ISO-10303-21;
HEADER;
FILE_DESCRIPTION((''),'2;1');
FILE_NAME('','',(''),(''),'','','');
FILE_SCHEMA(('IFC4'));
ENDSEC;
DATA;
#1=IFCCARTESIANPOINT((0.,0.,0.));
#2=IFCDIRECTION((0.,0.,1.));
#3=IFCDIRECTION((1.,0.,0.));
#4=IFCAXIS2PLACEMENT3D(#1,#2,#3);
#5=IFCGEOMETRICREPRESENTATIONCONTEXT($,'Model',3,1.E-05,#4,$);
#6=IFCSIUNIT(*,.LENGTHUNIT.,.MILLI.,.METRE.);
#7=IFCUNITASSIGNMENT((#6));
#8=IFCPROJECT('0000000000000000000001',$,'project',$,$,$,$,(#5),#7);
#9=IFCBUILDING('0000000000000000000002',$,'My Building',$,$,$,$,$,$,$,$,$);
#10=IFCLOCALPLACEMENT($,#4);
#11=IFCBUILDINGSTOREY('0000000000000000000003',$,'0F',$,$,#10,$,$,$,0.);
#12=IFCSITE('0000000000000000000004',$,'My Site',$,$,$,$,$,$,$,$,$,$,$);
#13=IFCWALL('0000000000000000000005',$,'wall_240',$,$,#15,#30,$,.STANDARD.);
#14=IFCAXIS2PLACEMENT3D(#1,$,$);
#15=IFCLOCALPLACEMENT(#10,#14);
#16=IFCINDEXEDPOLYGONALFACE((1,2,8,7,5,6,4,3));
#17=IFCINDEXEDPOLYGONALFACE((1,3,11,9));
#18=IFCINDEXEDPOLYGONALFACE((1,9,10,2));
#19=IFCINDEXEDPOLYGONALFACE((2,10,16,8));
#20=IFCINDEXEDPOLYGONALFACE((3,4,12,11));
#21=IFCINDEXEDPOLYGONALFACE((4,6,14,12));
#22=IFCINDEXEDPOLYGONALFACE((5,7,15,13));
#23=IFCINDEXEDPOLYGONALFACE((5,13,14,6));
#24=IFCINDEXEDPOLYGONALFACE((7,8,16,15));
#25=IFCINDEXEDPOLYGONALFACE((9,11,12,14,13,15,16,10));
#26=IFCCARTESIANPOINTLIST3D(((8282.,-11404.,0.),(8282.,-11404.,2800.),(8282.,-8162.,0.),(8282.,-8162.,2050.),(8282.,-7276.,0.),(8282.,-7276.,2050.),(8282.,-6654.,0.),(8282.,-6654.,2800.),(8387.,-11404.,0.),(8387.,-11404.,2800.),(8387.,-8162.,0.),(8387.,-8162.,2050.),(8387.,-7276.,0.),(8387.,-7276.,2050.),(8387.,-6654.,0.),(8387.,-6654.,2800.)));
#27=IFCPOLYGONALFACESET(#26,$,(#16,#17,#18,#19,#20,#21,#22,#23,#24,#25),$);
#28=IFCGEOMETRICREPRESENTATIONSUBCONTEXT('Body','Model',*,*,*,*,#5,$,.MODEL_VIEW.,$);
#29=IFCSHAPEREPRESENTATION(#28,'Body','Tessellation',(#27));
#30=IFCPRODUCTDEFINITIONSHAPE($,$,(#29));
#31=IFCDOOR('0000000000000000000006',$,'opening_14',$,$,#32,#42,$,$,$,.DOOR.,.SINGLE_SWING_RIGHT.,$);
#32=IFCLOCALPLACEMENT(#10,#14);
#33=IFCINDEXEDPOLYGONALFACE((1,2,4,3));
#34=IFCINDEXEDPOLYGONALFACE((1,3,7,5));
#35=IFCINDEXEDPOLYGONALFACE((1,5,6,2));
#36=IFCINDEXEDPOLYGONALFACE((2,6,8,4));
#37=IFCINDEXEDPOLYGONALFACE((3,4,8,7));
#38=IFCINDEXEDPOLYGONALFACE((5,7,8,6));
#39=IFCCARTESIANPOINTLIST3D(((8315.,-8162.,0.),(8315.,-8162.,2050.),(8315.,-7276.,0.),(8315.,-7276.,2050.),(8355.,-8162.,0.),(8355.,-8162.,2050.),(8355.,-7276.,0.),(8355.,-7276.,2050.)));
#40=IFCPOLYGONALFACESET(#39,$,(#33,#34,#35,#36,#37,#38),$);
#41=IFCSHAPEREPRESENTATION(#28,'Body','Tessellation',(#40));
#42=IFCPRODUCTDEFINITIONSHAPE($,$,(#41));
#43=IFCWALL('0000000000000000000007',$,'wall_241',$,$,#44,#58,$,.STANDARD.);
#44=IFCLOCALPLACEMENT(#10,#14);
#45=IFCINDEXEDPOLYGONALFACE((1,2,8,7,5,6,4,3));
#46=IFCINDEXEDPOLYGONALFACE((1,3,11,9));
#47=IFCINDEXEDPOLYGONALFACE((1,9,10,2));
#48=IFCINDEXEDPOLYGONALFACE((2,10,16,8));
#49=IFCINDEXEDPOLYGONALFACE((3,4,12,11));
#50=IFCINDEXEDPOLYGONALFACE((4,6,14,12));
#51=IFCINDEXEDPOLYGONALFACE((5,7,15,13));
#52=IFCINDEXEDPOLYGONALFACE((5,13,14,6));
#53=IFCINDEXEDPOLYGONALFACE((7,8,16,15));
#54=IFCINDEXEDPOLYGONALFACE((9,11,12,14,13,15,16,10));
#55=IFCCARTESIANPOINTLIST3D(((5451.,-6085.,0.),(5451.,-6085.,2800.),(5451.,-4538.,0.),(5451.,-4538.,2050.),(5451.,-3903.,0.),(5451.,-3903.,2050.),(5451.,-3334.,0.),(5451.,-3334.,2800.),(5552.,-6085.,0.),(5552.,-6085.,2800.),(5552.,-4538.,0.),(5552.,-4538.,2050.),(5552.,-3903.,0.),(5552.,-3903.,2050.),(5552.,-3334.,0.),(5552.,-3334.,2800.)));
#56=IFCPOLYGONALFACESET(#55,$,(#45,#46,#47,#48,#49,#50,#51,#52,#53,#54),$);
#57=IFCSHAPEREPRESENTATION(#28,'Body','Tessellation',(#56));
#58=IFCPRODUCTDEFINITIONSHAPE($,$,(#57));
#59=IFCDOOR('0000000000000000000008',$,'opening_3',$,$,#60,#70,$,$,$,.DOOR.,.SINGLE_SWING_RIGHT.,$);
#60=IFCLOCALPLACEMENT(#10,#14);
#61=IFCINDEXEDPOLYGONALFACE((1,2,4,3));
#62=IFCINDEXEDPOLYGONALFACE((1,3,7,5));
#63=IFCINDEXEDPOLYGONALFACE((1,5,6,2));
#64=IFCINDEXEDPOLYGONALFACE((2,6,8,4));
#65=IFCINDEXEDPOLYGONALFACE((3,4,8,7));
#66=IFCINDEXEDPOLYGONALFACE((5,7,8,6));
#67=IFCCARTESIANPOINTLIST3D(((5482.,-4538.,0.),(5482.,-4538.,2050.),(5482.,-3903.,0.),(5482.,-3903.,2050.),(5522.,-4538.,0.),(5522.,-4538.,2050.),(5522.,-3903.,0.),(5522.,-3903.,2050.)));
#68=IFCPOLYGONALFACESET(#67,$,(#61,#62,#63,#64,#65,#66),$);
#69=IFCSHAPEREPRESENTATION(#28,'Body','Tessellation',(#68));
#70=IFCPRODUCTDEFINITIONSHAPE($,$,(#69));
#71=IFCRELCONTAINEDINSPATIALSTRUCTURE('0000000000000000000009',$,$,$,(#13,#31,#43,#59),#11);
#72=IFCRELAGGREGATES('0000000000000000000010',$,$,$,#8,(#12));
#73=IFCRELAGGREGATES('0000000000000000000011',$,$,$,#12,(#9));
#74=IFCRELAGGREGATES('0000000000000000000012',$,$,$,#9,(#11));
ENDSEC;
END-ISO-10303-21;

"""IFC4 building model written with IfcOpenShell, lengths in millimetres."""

from ifc_helpers import new_model, si_unit, origin_with_axes, place, context, subcontext, project, spatial, indexed_curve, outline, extrude, element, fill, save


model = new_model("IFC4")

# Units and contexts
model_context = context("Model", 3, precision=1e-05, world=origin_with_axes())
body_context = subcontext(model_context, "Body", "Model", "MODEL_VIEW")
ifc_project = project(units=[si_unit("LENGTHUNIT", "METRE", prefix="MILLI")], contexts=[model_context])

# Site, building, storey
site = spatial("IfcSite", under=ifc_project, Name="My Site")
building = spatial("IfcBuilding", under=site, Name="My Building")
storey_placement = place(None, origin_with_axes())
storey = spatial("IfcBuildingStorey", under=building, at=storey_placement, Name="0F", Elevation=0.0)

# Walls, openings, doors
wall_1_placement = place(storey_placement, origin_with_axes())
wall_1 = element("IfcWall", 1, at=wall_1_placement, inside=storey, Name="wall_240", PredefinedType="STANDARD", context=body_context, shape_type="SweptSolid", body=[
    extrude(outline(indexed_curve([(8282.0, -6654.0), (8282.0, -11404.0), (8387.0, -11404.0), (8387.0, -6654.0), (8282.0, -6654.0)])), None, (0.0, 0.0, 1.0), 2800.0),
])
opening_1_placement = place(wall_1_placement, origin_with_axes())
opening_1 = element("IfcOpeningElement", 2, at=opening_1_placement, cuts=wall_1, ObjectType="Opening", context=body_context, shape_type="SweptSolid", body=[
    extrude(outline(indexed_curve([(8216.0, -8162.0), (8453.0, -8162.0), (8453.0, -7276.0), (8216.0, -7276.0), (8216.0, -8162.0)])), None, (0.0, 0.0, 1.0), 2050.0),
])
door_1_placement = place(opening_1_placement, origin_with_axes())
door_1 = element("IfcDoor", 3, at=door_1_placement, inside=storey, Name="opening_14", OperationType="SINGLE_SWING_RIGHT", PredefinedType="DOOR", context=body_context, shape_type="SweptSolid", body=[
    extrude(outline(indexed_curve([(8315.0, -8162.0), (8355.0, -8162.0), (8355.0, -7276.0), (8315.0, -7276.0), (8315.0, -8162.0)])), None, (0.0, 0.0, 1.0), 2050.0),
])
fill(opening_1, door_1)
wall_2_placement = place(storey_placement, origin_with_axes())
wall_2 = element("IfcWall", 4, at=wall_2_placement, inside=storey, Name="wall_241", PredefinedType="STANDARD", context=body_context, shape_type="SweptSolid", body=[
    extrude(outline(indexed_curve([(5451.0, -3334.0), (5451.0, -6085.0), (5552.0, -6085.0), (5552.0, -3334.0), (5451.0, -3334.0)])), None, (0.0, 0.0, 1.0), 2800.0),
])
opening_2_placement = place(wall_2_placement, origin_with_axes())
opening_2 = element("IfcOpeningElement", 5, at=opening_2_placement, cuts=wall_2, ObjectType="Opening", context=body_context, shape_type="SweptSolid", body=[
    extrude(outline(indexed_curve([(5385.0, -4538.0), (5618.0, -4538.0), (5618.0, -3903.0), (5385.0, -3903.0), (5385.0, -4538.0)])), None, (0.0, 0.0, 1.0), 2050.0),
])
door_2_placement = place(opening_2_placement, origin_with_axes())
door_2 = element("IfcDoor", 6, at=door_2_placement, inside=storey, Name="opening_3", OperationType="SINGLE_SWING_RIGHT", PredefinedType="DOOR", context=body_context, shape_type="SweptSolid", body=[
    extrude(outline(indexed_curve([(5482.0, -4538.0), (5522.0, -4538.0), (5522.0, -3903.0), (5482.0, -3903.0), (5482.0, -4538.0)])), None, (0.0, 0.0, 1.0), 2050.0),
])
fill(opening_2, door_2)

save(model, "model.ifc")
